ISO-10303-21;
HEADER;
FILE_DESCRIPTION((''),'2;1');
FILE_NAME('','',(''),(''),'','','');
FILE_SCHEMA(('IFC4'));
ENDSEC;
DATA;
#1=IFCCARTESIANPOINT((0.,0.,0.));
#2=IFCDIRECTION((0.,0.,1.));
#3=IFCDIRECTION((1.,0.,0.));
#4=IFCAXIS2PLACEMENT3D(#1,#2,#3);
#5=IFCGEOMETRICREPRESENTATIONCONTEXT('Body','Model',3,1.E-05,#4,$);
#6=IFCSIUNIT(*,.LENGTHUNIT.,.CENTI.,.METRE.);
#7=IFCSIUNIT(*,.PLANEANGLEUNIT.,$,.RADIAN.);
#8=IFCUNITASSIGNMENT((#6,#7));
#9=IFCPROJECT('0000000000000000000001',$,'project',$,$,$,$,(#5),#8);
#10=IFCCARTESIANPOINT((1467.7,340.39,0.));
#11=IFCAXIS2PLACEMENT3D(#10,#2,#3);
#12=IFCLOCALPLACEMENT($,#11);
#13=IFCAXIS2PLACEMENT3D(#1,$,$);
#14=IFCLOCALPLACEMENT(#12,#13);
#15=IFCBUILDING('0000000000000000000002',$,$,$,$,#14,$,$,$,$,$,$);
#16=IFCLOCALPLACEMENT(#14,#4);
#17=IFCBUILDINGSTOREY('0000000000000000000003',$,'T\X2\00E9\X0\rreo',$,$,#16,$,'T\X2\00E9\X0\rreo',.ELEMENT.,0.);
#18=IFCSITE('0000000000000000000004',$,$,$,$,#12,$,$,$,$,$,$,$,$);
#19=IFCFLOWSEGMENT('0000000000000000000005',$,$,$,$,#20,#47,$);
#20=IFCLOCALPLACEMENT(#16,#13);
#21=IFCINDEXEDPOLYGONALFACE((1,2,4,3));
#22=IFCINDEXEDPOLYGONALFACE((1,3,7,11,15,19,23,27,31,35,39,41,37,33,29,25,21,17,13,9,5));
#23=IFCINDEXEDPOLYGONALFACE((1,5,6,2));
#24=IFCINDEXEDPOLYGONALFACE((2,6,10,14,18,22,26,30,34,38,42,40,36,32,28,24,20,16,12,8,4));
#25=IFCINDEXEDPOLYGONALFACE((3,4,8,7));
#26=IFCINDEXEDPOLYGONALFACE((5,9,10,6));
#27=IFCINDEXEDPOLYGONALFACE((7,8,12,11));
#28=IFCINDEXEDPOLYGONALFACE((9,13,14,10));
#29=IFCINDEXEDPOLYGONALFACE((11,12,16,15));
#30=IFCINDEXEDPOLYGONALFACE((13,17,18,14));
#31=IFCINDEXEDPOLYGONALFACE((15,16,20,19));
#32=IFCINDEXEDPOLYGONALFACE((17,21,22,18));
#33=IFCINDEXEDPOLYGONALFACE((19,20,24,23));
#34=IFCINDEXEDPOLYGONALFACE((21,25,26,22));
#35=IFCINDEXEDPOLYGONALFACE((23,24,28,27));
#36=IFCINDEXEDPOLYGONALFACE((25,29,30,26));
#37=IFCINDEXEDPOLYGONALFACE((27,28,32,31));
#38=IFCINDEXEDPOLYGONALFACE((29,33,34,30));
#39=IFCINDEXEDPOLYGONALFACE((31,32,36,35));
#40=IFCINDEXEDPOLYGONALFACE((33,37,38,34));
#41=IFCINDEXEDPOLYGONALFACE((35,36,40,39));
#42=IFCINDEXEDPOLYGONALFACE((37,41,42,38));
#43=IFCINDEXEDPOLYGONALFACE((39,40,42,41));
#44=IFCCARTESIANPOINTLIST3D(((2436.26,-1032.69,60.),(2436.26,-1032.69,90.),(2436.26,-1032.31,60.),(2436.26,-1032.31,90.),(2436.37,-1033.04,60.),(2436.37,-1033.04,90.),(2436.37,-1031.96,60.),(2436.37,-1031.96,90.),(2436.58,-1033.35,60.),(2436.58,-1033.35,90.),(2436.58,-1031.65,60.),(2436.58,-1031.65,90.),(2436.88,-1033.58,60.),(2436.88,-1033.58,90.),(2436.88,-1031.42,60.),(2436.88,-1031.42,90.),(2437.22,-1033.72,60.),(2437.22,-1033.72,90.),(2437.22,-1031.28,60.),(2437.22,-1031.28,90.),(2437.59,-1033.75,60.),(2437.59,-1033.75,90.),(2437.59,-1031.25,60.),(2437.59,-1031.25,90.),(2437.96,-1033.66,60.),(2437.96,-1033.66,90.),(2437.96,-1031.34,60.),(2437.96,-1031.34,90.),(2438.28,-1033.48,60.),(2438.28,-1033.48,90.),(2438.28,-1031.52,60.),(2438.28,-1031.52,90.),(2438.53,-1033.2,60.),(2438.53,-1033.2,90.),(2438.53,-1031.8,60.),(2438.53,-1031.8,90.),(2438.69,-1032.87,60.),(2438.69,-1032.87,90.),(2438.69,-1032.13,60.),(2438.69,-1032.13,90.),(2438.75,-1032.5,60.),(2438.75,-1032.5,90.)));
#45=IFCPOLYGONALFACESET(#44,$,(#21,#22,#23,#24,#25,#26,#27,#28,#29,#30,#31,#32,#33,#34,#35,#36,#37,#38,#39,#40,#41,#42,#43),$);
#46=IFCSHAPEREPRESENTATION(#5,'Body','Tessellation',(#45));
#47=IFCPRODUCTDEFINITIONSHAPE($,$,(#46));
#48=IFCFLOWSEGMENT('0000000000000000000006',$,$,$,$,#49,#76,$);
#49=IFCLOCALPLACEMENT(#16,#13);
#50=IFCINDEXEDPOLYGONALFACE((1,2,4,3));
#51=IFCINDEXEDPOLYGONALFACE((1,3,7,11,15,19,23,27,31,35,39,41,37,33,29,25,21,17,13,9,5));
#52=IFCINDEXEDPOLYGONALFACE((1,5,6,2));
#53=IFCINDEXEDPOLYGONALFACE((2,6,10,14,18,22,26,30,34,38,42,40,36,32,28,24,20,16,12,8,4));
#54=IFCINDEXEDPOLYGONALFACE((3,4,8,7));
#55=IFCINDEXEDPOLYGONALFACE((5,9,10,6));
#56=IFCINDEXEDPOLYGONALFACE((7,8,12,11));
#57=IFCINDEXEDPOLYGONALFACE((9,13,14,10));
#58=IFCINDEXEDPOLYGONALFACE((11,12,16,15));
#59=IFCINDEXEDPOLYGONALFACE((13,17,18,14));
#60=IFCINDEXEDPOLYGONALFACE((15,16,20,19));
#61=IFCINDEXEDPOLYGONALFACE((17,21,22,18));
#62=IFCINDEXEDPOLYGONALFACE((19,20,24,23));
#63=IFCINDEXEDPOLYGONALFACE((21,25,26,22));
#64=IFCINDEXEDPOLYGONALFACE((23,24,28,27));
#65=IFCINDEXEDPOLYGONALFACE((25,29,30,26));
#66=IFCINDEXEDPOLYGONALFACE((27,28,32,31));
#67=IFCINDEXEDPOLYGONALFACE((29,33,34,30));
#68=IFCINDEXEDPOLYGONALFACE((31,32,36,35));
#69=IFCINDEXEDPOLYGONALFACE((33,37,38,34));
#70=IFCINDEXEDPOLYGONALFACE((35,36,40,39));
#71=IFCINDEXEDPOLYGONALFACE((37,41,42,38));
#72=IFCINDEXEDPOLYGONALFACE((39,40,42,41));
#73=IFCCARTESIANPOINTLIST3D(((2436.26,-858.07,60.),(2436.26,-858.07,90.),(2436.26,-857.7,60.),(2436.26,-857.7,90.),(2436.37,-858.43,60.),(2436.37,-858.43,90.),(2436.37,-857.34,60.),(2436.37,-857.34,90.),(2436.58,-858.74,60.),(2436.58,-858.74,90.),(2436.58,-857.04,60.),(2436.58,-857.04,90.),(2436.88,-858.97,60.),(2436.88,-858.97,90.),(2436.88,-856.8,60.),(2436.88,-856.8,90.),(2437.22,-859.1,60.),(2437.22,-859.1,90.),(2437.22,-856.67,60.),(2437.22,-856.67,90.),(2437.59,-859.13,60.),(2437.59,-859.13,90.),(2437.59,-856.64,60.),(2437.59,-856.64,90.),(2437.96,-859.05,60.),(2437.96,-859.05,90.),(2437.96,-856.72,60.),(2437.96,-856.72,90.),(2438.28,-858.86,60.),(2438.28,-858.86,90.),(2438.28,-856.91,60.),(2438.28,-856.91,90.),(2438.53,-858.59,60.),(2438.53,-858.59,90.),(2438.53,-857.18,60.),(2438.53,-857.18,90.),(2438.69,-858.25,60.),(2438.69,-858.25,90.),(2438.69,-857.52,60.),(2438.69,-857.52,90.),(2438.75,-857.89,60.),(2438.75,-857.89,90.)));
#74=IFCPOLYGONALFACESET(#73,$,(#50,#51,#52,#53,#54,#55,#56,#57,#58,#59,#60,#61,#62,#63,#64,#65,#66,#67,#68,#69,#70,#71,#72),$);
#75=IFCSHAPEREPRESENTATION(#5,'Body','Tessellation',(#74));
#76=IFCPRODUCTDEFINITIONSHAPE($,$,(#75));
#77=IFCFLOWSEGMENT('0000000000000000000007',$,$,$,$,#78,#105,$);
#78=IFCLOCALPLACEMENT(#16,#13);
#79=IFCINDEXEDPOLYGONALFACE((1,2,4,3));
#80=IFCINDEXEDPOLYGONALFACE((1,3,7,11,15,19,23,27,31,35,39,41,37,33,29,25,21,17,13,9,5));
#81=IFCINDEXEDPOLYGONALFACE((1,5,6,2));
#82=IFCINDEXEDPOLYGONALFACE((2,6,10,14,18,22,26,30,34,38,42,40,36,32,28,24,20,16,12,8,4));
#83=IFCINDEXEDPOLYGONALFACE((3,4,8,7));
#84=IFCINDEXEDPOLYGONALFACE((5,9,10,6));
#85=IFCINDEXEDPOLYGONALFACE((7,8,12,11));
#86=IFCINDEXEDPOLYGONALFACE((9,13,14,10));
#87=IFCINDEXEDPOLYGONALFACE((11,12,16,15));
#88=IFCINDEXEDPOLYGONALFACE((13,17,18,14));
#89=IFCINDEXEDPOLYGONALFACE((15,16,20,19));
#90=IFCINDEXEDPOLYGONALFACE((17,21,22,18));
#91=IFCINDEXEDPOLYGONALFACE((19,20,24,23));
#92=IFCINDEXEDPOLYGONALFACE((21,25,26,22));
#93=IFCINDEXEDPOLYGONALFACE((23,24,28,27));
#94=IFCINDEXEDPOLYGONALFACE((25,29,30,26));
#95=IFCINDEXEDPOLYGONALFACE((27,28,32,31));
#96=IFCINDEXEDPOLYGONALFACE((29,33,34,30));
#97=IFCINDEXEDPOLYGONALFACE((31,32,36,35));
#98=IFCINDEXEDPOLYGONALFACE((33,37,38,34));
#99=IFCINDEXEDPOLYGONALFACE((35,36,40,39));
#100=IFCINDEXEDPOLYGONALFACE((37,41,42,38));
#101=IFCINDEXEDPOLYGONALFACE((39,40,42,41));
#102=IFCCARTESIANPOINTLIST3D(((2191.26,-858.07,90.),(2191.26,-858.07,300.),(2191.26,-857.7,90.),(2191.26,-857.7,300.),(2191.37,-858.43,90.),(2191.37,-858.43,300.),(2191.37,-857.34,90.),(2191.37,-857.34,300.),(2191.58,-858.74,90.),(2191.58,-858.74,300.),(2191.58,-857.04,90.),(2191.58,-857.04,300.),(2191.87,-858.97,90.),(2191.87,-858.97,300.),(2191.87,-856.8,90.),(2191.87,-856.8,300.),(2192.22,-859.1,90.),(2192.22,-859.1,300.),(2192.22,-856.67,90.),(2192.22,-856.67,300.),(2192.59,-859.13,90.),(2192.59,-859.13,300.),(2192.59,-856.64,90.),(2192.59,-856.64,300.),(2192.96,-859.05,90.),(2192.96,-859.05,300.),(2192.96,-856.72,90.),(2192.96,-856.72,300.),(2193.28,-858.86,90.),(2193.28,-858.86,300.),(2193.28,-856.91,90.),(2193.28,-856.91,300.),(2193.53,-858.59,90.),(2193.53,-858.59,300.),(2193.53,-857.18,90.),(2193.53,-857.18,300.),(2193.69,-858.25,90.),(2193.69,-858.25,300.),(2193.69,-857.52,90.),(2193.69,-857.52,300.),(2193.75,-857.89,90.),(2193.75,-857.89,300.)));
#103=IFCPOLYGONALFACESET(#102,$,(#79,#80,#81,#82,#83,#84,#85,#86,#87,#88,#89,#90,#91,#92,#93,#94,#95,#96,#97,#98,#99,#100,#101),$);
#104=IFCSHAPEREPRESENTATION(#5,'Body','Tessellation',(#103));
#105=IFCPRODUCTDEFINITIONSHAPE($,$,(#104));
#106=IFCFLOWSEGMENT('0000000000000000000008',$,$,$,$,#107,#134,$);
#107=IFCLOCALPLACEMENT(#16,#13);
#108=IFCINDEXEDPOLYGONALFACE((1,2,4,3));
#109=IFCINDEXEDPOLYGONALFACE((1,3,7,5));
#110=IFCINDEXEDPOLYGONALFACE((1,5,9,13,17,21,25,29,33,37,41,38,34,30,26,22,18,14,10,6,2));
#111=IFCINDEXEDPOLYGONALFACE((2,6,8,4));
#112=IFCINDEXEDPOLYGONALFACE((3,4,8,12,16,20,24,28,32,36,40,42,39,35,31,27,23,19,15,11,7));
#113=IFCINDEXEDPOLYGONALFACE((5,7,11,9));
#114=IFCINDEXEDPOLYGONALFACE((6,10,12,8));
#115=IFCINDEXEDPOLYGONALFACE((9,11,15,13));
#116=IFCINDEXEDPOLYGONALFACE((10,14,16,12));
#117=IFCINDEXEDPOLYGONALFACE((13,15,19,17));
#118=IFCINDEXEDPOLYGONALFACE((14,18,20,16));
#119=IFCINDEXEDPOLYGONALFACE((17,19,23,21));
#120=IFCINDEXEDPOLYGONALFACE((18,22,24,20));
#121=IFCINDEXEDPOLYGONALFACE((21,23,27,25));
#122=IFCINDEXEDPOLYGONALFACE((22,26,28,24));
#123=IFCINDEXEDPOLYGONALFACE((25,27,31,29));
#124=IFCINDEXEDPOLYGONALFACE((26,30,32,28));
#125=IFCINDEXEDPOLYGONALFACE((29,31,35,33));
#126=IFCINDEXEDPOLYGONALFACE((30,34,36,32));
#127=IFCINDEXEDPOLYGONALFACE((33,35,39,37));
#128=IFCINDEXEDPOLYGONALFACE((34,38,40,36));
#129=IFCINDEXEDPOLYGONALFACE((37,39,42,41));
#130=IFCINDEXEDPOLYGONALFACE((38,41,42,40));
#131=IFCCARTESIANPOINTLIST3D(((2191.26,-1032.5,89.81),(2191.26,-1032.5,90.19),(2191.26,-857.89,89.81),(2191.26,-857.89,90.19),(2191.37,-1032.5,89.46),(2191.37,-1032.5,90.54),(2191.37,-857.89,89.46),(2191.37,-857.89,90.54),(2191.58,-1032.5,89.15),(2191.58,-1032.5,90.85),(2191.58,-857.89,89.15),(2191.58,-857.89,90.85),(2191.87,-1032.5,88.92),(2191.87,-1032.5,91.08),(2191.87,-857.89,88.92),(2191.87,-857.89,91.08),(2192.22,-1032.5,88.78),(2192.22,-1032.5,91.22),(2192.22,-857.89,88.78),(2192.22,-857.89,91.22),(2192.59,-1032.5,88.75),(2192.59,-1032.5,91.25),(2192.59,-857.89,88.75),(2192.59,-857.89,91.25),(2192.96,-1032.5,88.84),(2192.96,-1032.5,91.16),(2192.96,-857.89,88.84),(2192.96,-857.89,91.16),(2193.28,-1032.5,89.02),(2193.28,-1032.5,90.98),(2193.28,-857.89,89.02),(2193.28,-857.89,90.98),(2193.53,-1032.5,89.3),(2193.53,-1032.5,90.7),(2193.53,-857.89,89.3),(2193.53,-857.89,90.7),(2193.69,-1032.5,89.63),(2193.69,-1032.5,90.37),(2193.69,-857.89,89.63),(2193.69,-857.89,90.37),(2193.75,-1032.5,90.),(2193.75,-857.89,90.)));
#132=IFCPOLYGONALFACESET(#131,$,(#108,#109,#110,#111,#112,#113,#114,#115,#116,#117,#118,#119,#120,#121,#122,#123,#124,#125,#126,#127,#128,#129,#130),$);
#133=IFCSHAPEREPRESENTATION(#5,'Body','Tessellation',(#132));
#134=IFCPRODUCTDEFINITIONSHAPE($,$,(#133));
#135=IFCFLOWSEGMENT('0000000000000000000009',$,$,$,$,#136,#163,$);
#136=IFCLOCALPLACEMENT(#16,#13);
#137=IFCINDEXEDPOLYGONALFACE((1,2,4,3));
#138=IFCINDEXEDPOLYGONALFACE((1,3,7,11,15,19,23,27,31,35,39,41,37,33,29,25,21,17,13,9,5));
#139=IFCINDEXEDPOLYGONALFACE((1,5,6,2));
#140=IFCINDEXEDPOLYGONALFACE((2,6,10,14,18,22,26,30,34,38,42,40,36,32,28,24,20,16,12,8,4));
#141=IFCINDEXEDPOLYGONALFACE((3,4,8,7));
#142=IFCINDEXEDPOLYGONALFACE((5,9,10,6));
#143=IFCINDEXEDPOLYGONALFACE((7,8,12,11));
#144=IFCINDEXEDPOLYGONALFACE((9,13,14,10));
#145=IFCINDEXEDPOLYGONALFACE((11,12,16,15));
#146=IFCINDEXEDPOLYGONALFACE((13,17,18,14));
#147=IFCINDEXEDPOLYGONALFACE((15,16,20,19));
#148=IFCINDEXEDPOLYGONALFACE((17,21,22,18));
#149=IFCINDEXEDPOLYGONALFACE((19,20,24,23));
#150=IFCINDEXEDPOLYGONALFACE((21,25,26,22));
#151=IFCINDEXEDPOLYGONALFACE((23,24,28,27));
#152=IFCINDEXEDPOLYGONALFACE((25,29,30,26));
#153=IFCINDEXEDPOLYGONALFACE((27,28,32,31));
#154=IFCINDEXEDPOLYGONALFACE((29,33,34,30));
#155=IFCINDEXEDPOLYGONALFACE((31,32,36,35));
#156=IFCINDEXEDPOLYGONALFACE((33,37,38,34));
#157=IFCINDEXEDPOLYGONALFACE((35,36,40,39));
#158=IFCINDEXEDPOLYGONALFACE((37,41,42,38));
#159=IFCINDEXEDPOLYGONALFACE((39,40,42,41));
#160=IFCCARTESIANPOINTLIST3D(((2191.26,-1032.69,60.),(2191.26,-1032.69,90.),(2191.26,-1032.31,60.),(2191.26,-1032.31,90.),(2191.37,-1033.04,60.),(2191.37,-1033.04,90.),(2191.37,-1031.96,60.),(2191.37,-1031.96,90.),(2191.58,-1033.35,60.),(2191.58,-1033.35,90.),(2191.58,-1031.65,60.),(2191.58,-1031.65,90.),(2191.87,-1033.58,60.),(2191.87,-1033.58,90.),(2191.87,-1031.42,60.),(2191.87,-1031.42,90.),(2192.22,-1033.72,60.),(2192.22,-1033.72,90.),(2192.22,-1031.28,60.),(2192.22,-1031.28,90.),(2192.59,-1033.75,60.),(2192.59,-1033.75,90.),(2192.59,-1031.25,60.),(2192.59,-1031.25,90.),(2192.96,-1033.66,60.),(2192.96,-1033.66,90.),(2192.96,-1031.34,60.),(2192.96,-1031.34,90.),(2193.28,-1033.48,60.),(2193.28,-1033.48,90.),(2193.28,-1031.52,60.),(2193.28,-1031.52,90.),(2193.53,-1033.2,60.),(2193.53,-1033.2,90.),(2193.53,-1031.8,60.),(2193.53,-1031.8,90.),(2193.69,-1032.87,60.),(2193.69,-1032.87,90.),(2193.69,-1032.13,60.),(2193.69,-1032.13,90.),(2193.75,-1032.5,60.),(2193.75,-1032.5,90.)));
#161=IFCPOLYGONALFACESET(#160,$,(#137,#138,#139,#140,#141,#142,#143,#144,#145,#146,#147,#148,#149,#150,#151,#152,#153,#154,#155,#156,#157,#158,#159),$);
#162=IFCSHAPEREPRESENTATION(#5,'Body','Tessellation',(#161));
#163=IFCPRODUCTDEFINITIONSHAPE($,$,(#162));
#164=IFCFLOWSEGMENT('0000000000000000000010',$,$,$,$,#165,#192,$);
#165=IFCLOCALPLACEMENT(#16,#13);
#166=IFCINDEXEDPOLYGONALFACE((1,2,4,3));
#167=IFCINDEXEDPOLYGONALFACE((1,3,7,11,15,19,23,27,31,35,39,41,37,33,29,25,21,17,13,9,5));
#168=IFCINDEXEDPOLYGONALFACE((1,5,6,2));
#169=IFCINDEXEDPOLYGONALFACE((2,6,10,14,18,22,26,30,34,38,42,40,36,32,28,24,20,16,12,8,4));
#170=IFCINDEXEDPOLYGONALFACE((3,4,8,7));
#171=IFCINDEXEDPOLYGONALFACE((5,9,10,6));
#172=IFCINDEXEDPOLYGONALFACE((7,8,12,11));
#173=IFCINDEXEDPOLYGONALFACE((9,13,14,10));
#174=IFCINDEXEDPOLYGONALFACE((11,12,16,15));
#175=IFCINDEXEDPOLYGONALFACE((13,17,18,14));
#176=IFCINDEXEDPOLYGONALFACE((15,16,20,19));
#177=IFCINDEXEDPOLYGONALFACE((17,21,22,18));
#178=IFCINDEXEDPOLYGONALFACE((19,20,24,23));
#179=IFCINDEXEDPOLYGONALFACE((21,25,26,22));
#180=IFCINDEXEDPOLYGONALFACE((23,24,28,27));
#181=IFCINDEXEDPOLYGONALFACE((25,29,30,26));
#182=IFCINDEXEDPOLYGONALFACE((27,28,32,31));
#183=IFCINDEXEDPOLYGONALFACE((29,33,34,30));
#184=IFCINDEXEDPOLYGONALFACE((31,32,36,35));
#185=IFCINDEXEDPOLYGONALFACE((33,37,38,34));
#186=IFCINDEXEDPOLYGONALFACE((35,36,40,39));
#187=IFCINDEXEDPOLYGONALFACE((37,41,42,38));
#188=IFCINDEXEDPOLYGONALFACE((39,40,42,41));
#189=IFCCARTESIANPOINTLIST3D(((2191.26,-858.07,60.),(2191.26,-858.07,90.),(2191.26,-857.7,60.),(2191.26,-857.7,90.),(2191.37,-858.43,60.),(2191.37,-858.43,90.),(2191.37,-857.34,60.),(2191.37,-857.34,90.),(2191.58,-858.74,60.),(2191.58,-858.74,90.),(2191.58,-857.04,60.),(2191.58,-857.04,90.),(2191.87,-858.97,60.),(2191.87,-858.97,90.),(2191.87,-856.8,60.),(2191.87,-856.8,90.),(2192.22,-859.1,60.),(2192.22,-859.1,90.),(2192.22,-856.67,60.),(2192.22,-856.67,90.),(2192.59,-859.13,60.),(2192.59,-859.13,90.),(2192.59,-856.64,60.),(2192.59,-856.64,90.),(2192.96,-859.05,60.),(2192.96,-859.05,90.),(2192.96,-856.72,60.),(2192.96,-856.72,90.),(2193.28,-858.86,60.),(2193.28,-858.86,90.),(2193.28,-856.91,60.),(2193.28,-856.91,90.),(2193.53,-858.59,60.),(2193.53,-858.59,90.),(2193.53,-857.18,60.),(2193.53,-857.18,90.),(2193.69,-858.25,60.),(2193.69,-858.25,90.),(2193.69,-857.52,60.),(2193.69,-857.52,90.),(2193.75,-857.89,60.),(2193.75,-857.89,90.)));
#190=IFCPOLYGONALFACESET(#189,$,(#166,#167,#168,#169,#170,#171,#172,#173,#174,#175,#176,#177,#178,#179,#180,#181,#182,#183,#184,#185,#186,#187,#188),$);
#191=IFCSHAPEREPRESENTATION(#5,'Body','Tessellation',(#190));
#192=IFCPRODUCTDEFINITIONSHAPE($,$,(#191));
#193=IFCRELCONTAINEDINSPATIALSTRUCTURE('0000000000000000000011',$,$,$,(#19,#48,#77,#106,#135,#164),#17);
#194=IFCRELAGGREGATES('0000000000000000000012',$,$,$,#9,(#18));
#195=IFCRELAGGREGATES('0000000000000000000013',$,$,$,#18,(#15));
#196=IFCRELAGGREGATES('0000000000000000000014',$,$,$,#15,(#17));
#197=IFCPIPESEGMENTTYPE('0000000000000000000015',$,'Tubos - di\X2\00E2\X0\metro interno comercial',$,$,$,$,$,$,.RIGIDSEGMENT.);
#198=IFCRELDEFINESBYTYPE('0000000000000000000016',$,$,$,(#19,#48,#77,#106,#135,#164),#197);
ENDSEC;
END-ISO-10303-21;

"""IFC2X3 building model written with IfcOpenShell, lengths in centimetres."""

from ifc_helpers import new_model, si_unit, frame, origin, origin_with_axes, origin_2d_with_axis, place, context, project, spatial, circle, extrude, type_object, element, save


model = new_model("IFC2X3")

# Units and contexts
model_context = context("Model", 3, precision=1e-05, world=origin_with_axes(), identifier="Body")
ifc_project = project(units=[si_unit("LENGTHUNIT", "METRE", prefix="CENTI"), si_unit("PLANEANGLEUNIT", "RADIAN")], contexts=[model_context])

# Site, building, storey
site_placement = place(None, frame((1467.7, 340.39, 0.0), z_axis=(0.0, 0.0, 1.0), x_axis=(1.0, 0.0, 0.0)))
site = spatial("IfcSite", under=ifc_project, at=site_placement)
building_placement = place(site_placement, origin())
building = spatial("IfcBuilding", under=site, at=building_placement)
storey_placement = place(building_placement, origin_with_axes())
storey = spatial("IfcBuildingStorey", under=building, at=storey_placement, Name="Térreo", LongName="Térreo", CompositionType="ELEMENT", Elevation=0.0)

# Flow segments
pipe_segment_type_1 = type_object("IfcPipeSegmentType", Name="Tubos - diâmetro interno comercial", PredefinedType="RIGIDSEGMENT")
for number, where, z_axis, x_axis in (
    (1, (2437.5, -1032.5, 90.0), (0.0, 0.0, 1.0), (1.0, 0.0, 0.0)),
    (2, (2437.5, -857.89, 90.0), (0.0, 0.0, 1.0), (1.0, 0.0, 0.0)),
):
    element("IfcFlowSegment", number, at=place(storey_placement, frame(where, z_axis=z_axis, x_axis=x_axis)), inside=storey, type_object=pipe_segment_type_1, context=model_context, shape_type="SolidModel", body=[
        extrude(circle(Radius=1.25, at=origin_2d_with_axis()), frame((0.0, 0.0, 0.0), z_axis=(0.0, 0.0, -1.0), x_axis=(1.0, 0.0, 0.0)), (0.0, 0.0, 1.0), 30.0),
    ])
flow_segment_1_placement = place(storey_placement, frame((2192.5, -857.89, 300.0), z_axis=(0.0, 0.0, 1.0), x_axis=(1.0, 0.0, 0.0)))
element("IfcFlowSegment", 3, at=flow_segment_1_placement, inside=storey, type_object=pipe_segment_type_1, context=model_context, shape_type="SolidModel", body=[
    extrude(circle(Radius=1.25, at=origin_2d_with_axis()), frame((0.0, 0.0, 0.0), z_axis=(0.0, 0.0, -1.0), x_axis=(1.0, 0.0, 0.0)), (0.0, 0.0, 1.0), 210.0),
])
flow_segment_2_placement = place(storey_placement, frame((2192.5, -945.19, 91.25), z_axis=(0.0, 0.0, 1.0), x_axis=(1.0, 0.0, 0.0)))
element("IfcFlowSegment", 4, at=flow_segment_2_placement, inside=storey, type_object=pipe_segment_type_1, context=model_context, shape_type="SolidModel", body=[
    extrude(circle(Radius=1.25, at=origin_2d_with_axis()), frame((0.0, 87.31, -1.25), z_axis=(0.0, -1.0, 0.0), x_axis=(1.0, 0.0, 0.0)), (0.0, 0.0, 1.0), 174.61),
])
for number, where, z_axis, x_axis in (
    (5, (2192.5, -1032.5, 90.0), (0.0, 0.0, 1.0), (1.0, 0.0, 0.0)),
    (6, (2192.5, -857.89, 90.0), (0.0, 0.0, 1.0), (1.0, 0.0, 0.0)),
):
    element("IfcFlowSegment", number, at=place(storey_placement, frame(where, z_axis=z_axis, x_axis=x_axis)), inside=storey, type_object=pipe_segment_type_1, context=model_context, shape_type="SolidModel", body=[
        extrude(circle(Radius=1.25, at=origin_2d_with_axis()), frame((0.0, 0.0, 0.0), z_axis=(0.0, 0.0, -1.0), x_axis=(1.0, 0.0, 0.0)), (0.0, 0.0, 1.0), 30.0),
    ])

save(model, "model.ifc")
